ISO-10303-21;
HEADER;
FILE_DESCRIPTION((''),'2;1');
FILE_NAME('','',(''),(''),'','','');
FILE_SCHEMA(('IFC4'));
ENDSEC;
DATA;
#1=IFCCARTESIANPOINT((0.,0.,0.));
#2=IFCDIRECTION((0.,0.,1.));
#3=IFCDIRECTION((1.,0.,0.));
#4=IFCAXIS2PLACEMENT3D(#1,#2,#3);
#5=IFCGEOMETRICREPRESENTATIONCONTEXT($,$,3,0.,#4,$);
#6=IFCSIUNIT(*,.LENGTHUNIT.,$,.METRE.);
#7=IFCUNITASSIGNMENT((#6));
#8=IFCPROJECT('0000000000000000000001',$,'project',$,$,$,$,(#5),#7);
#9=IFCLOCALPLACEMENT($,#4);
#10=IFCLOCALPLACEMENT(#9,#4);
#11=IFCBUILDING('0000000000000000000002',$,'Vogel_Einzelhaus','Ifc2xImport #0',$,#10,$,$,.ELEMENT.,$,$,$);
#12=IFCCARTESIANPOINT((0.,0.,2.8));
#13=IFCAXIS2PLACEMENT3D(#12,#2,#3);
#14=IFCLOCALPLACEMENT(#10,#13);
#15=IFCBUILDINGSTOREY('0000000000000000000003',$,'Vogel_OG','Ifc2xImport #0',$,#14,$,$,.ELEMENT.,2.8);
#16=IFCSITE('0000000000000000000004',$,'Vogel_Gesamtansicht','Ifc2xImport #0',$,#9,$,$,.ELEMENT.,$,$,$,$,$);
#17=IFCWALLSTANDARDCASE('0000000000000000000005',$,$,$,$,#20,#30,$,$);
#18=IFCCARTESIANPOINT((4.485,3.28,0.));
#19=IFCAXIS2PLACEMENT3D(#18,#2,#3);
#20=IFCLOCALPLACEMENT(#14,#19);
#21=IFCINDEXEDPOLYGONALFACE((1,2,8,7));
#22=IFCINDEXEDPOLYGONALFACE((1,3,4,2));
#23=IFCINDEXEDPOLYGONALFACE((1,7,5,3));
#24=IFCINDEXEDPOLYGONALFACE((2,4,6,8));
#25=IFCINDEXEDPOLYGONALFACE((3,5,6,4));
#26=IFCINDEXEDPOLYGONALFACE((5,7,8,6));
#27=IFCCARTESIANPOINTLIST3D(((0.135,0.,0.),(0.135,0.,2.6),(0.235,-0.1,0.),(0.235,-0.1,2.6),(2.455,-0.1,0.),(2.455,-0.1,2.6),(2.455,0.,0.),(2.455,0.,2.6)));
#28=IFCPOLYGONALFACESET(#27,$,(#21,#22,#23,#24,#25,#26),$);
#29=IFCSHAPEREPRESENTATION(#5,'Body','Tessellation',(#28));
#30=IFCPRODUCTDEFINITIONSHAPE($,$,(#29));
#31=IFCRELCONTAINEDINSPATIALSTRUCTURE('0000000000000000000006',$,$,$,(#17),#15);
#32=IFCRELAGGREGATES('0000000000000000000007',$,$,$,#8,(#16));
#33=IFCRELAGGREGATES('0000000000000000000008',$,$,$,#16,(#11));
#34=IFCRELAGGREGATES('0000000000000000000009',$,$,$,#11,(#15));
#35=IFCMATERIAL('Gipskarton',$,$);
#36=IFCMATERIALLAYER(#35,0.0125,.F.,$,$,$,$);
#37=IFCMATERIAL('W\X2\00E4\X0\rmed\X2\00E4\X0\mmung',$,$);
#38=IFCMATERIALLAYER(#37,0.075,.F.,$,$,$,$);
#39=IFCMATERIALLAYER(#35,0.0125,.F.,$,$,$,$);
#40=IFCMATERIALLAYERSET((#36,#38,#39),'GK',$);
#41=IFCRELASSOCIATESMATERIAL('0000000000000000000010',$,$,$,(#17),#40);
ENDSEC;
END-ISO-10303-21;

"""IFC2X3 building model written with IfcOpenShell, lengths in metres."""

from ifc_helpers import new_model, si_unit, frame, origin_with_axes, place, context, project, spatial, polyline, outline, extrude, material, layer, layer_set, layer_usage, element, save


model = new_model("IFC2X3")

# Units and contexts
context_of_model = context(None, 3, precision=0.0, world=origin_with_axes())
ifc_project = project(units=[si_unit("LENGTHUNIT", "METRE")], contexts=[context_of_model])

# Site, building, storey
site_placement = place(None, origin_with_axes())
site = spatial("IfcSite", under=ifc_project, at=site_placement, Name="Vogel_Gesamtansicht", Description="Ifc2xImport #0", CompositionType="ELEMENT")
building_placement = place(site_placement, origin_with_axes())
building = spatial("IfcBuilding", under=site, at=building_placement, Name="Vogel_Einzelhaus", Description="Ifc2xImport #0", CompositionType="ELEMENT")
storey_placement = place(building_placement, frame((0.0, 0.0, 2.8), z_axis=(0.0, 0.0, 1.0), x_axis=(1.0, 0.0, 0.0)))
storey = spatial("IfcBuildingStorey", under=building, at=storey_placement, Name="Vogel_OG", Description="Ifc2xImport #0", CompositionType="ELEMENT", Elevation=2.8)

# Wall
ifc_material_1 = material(Name="Gipskarton")
ifc_layer_1 = layer(ifc_material_1, 0.0125, ventilated=False)
ifc_material_2 = material(Name="Wärmedämmung")
ifc_layer_2 = layer(ifc_material_2, 0.075, ventilated=False)
ifc_layer_3 = layer(ifc_material_1, 0.0125, ventilated=False)
ifc_layer_set_1 = layer_set([ifc_layer_1, ifc_layer_2, ifc_layer_3], Name="GK")
ifc_layer_usage_1 = layer_usage(ifc_layer_set_1, "AXIS2", "POSITIVE", -0.1)
wall_1_placement = place(storey_placement, frame((4.485, 3.28, 0.0), z_axis=(0.0, 0.0, 1.0), x_axis=(1.0, 0.0, 0.0)))
element("IfcWallStandardCase", 1, at=wall_1_placement, inside=storey, material=ifc_layer_usage_1, context=context_of_model, shape_type="SweptSolid", body=[
    extrude(outline(polyline([(0.235, -0.1), (2.455, -0.1), (2.455, 0.0), (0.135, 0.0), (0.235, -0.1)])), origin_with_axes(), (0.0, 0.0, 1.0), 2.6),
])

save(model, "model.ifc")
